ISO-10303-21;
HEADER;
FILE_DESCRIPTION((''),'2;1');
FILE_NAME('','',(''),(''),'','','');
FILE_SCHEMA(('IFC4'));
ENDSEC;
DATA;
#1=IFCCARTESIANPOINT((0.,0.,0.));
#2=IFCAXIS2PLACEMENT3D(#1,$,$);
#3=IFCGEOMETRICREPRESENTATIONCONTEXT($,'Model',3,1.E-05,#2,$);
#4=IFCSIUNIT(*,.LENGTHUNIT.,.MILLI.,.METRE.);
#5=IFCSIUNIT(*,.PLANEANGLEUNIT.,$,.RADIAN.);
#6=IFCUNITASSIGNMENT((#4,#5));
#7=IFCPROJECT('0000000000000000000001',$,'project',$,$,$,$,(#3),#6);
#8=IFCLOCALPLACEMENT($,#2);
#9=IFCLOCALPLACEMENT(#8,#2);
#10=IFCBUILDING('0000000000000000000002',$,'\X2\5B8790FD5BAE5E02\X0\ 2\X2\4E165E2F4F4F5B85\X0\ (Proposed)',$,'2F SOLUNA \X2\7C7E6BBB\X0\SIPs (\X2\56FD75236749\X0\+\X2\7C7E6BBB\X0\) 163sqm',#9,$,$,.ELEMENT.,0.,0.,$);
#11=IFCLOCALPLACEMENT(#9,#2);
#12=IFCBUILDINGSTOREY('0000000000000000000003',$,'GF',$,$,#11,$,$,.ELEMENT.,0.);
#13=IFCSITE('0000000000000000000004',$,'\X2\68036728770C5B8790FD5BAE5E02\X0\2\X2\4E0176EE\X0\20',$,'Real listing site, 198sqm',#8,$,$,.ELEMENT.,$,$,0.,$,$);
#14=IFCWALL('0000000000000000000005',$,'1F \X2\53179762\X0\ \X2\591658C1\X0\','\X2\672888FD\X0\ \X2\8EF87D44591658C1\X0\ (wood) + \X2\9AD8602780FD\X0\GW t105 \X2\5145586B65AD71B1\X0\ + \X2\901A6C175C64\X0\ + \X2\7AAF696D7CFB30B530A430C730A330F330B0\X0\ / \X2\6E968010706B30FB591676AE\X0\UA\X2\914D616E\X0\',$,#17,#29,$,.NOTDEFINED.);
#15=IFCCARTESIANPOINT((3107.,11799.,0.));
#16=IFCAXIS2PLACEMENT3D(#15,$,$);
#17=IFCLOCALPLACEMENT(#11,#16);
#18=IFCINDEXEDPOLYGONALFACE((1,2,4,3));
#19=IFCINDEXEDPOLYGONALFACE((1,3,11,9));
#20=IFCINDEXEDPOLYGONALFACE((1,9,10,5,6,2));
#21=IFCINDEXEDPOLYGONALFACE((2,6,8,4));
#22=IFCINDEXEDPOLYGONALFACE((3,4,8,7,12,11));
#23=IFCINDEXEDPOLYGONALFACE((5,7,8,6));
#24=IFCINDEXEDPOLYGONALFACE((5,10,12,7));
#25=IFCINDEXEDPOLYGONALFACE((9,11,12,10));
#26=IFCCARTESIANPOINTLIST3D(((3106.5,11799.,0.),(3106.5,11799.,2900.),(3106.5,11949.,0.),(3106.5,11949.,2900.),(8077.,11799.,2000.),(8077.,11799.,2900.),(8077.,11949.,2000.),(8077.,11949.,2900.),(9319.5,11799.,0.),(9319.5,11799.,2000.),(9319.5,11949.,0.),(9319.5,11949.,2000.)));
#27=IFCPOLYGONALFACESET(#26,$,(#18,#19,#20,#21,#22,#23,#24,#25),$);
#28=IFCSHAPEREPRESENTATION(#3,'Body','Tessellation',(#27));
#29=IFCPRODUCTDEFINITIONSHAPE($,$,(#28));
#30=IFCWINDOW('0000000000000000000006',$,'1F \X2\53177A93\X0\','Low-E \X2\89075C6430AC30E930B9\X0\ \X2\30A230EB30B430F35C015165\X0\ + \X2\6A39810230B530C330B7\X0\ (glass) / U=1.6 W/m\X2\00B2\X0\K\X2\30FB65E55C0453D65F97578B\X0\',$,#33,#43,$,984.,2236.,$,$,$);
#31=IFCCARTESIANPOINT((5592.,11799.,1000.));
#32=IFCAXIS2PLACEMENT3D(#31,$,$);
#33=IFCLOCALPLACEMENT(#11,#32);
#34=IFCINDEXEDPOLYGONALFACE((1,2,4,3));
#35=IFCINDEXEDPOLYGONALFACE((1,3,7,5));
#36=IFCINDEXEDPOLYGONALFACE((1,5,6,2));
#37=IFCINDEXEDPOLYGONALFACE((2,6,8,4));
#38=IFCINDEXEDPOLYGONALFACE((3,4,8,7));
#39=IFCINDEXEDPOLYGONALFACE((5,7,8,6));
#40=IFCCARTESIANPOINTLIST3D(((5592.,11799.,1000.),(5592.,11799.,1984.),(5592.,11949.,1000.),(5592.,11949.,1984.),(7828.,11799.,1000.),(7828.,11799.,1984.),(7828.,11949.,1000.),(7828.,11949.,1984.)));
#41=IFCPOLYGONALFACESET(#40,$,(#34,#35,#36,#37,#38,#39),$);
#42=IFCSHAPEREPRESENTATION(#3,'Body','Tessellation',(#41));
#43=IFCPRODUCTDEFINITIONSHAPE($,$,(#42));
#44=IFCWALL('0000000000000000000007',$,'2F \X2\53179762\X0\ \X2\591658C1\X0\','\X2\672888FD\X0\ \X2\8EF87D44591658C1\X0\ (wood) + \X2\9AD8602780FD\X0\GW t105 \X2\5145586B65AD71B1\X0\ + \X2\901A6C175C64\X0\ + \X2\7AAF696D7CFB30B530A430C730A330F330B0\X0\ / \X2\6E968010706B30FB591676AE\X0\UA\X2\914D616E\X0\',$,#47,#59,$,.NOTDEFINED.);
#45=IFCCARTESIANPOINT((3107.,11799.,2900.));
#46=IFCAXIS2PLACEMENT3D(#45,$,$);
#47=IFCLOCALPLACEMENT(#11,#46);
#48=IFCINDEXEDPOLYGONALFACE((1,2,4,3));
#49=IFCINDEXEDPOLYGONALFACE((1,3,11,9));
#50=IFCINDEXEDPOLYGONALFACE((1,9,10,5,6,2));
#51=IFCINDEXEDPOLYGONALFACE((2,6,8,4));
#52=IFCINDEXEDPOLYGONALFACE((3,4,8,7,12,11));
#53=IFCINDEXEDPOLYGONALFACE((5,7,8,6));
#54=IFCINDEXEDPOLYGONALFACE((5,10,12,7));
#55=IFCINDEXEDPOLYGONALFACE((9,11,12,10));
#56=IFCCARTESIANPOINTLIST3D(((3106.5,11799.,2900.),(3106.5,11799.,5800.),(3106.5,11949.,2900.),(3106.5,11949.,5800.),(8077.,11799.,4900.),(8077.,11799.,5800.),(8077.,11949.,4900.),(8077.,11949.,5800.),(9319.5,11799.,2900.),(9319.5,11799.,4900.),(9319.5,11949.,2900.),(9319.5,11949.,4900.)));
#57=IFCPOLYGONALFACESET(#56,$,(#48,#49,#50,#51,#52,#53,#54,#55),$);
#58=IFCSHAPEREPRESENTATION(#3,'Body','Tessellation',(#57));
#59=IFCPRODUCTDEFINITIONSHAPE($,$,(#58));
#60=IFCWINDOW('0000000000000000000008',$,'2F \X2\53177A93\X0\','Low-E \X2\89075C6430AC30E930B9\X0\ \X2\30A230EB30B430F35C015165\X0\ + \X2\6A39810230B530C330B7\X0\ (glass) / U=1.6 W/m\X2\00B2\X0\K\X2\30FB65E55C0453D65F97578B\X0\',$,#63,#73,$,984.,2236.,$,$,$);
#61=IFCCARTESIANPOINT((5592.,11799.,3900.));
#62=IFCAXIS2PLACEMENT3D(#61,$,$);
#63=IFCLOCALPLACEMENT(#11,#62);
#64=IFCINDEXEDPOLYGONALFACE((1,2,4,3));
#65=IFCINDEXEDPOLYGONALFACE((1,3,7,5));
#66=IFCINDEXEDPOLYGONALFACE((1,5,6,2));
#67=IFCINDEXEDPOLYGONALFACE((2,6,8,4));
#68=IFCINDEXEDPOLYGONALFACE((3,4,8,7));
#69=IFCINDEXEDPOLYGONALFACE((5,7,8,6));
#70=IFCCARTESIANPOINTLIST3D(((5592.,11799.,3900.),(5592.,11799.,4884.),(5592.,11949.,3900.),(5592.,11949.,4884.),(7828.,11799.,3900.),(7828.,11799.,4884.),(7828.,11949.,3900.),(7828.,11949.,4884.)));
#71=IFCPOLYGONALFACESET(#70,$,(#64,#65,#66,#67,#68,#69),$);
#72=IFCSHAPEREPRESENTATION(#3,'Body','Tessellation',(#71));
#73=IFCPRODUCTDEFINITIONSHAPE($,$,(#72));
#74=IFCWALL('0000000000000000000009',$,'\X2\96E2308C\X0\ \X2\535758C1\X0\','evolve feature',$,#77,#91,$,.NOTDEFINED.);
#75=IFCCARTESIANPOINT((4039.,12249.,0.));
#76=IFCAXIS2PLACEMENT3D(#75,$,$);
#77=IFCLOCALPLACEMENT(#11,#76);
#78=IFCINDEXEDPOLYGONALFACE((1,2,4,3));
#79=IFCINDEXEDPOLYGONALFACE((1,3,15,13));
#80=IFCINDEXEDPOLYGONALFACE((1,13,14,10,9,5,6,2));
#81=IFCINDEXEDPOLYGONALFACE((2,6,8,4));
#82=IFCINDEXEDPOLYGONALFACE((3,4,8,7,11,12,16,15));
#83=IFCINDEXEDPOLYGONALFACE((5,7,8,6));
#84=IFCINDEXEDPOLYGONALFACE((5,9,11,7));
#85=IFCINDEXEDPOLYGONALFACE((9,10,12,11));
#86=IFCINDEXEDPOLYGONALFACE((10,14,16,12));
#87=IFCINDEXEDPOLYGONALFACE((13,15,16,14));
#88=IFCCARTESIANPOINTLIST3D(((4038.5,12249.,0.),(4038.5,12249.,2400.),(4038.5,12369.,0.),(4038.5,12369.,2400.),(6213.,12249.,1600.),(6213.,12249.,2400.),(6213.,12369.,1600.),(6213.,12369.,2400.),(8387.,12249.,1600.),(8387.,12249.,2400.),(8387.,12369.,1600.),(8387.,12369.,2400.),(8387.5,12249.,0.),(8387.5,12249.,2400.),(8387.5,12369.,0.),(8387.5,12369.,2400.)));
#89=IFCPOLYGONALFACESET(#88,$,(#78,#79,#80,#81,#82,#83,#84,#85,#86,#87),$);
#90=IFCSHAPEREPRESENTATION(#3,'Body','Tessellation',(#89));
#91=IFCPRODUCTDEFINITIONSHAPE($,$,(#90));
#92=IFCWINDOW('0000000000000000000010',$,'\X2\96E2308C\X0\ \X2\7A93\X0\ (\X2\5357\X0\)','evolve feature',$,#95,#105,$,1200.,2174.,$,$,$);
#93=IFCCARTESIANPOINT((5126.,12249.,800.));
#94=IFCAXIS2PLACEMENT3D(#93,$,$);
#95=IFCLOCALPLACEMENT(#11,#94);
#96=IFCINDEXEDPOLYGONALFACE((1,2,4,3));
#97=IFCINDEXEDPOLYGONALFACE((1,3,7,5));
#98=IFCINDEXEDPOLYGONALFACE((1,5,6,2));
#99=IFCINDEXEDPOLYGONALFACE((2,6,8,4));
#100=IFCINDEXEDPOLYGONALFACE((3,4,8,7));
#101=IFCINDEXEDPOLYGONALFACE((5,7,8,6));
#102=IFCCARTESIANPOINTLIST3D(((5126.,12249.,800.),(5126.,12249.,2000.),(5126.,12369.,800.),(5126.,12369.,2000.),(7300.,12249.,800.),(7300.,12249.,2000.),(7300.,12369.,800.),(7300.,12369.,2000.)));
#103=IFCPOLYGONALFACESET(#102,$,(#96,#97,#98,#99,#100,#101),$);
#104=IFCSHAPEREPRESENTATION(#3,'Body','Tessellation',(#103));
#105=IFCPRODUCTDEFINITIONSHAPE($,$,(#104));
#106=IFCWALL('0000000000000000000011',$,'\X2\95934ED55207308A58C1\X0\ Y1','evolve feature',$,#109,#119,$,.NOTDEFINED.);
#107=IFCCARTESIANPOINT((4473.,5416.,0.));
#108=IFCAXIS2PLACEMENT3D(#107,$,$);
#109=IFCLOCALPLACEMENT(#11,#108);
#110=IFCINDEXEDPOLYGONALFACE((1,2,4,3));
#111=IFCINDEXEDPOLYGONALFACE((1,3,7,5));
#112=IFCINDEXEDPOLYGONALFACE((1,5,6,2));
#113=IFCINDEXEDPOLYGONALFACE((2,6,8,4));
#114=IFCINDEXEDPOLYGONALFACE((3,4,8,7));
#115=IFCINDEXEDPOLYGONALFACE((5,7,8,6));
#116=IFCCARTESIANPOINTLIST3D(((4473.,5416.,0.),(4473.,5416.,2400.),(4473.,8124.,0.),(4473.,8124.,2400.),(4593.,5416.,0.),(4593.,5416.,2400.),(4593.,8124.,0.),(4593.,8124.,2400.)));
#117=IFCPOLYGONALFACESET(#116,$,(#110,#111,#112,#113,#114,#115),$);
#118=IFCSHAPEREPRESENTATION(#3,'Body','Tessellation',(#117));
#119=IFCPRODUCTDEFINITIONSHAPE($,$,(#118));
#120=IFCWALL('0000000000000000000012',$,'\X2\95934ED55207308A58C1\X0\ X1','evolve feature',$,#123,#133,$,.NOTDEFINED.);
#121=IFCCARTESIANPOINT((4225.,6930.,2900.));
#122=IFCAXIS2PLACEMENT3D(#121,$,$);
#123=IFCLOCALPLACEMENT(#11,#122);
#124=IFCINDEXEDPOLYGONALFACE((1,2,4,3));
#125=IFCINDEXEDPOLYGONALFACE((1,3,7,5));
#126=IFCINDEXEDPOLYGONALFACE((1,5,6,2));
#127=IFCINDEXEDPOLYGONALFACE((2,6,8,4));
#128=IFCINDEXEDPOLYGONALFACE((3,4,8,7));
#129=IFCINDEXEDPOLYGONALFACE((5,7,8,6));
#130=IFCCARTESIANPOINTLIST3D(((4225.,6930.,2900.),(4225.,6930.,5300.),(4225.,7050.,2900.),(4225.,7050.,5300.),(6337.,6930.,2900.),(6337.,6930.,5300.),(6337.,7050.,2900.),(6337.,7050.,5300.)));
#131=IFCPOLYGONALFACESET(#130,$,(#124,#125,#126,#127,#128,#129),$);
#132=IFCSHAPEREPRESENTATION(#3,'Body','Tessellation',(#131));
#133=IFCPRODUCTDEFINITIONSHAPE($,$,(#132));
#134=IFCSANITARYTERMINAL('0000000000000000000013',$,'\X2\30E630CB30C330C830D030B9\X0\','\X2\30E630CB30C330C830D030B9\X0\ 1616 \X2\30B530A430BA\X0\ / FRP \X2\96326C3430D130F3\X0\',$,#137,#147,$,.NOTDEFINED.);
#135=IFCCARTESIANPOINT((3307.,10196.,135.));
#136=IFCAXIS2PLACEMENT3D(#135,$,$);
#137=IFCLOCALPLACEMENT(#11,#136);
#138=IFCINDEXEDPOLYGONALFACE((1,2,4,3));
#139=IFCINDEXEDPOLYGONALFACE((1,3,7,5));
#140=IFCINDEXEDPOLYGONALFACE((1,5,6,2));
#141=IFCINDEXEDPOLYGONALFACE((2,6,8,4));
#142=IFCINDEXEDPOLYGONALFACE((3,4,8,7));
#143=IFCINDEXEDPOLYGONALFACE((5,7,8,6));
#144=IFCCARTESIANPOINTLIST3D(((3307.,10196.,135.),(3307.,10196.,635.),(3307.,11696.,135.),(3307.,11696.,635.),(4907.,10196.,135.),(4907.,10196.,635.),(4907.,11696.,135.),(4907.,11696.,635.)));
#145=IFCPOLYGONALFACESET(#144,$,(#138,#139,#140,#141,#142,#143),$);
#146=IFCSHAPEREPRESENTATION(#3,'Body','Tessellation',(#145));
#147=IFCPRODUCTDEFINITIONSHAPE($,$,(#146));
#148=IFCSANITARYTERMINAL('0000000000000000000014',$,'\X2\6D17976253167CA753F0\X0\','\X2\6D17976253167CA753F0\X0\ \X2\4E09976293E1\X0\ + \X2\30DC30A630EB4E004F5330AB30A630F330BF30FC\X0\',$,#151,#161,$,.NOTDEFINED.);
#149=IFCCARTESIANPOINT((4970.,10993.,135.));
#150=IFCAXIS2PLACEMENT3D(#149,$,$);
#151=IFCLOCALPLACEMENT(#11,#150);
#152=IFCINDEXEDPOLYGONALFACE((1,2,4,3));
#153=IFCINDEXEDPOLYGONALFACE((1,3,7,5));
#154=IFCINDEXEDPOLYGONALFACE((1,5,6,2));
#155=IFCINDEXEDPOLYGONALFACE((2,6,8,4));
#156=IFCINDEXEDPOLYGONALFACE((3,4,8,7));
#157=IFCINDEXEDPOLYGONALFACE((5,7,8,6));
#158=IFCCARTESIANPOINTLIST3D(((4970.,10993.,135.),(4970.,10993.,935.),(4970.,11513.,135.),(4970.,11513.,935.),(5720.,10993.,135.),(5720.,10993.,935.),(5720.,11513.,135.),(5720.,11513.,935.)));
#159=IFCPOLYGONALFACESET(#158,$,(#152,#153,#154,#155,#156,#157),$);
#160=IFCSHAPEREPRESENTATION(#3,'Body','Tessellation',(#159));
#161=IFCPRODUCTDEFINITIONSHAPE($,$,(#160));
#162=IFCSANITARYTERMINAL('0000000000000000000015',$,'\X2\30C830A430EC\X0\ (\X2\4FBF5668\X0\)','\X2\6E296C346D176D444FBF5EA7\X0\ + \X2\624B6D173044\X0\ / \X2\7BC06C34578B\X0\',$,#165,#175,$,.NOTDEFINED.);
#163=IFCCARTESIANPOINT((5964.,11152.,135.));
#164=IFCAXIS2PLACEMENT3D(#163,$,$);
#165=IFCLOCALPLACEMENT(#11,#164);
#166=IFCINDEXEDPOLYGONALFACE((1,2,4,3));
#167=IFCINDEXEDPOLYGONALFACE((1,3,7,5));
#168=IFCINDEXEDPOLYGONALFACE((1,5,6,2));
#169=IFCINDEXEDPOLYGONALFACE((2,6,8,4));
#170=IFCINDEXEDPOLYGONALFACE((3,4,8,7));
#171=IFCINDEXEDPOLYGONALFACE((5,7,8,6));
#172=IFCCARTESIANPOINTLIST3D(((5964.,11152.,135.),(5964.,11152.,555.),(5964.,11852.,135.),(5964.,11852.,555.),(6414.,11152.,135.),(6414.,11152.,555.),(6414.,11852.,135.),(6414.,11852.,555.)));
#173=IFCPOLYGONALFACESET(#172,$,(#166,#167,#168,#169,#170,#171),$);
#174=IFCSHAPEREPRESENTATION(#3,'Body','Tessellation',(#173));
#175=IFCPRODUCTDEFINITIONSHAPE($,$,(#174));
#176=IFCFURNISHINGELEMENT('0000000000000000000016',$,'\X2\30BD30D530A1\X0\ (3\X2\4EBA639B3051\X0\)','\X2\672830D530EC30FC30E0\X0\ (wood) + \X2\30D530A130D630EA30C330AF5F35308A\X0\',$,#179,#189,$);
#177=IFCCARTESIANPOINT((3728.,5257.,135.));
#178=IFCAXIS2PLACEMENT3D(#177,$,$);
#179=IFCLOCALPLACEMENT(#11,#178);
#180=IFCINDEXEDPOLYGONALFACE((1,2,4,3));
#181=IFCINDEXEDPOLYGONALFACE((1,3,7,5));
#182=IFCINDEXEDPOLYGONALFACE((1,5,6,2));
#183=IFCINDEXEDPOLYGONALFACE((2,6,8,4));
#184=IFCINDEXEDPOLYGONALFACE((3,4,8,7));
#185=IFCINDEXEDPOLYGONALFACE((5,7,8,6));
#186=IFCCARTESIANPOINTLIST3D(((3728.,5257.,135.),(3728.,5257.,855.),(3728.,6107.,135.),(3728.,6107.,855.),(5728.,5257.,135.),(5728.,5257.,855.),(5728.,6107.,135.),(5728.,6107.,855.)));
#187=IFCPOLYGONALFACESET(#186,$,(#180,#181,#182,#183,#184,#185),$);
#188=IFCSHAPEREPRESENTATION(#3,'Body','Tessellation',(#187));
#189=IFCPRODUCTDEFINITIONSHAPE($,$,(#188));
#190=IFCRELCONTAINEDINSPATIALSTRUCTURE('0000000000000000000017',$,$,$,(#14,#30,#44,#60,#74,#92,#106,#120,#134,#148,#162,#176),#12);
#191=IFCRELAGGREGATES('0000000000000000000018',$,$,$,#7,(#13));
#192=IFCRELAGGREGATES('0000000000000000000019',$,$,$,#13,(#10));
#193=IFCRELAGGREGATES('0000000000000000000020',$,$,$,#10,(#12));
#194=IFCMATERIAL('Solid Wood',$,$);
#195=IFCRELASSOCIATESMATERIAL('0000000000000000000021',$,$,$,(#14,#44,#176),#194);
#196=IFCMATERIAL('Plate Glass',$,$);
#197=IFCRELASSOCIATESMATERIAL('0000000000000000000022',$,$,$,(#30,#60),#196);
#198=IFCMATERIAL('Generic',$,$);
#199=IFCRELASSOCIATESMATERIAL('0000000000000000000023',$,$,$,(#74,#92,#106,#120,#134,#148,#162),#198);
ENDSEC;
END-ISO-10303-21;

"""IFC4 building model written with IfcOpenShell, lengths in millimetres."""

from ifc_helpers import new_model, si_unit, frame, frame_2d, origin, place, context, project, spatial, rectangle, extrude, material, element, fill, save


model = new_model("IFC4")

# Units and contexts
model_context = context("Model", 3, precision=1e-05, world=origin())
ifc_project = project(units=[si_unit("LENGTHUNIT", "METRE", prefix="MILLI"), si_unit("PLANEANGLEUNIT", "RADIAN")], contexts=[model_context])

# Site, building, storey
site_placement = place(None, origin())
site = spatial("IfcSite", under=ifc_project, at=site_placement, Name="栃木県宇都宮市2丁目20", ObjectType="Real listing site, 198sqm", CompositionType="ELEMENT", RefElevation=0.0)
building_placement = place(site_placement, origin())
building = spatial("IfcBuilding", under=site, at=building_placement, Name="宇都宮市 2世帯住宅 (Proposed)", ObjectType="2F SOLUNA 籾殻SIPs (国産杉+籾殻) 163sqm", CompositionType="ELEMENT", ElevationOfRefHeight=0.0, ElevationOfTerrain=0.0)
storey_placement = place(building_placement, origin())
storey = spatial("IfcBuildingStorey", under=building, at=storey_placement, Name="GF", CompositionType="ELEMENT", Elevation=0.0)

# Shared definitions
ifc_material_1 = material(Name="Generic")

# Wall, opening, window
ifc_material_2 = material(Name="Solid Wood")
wall_1_placement = place(storey_placement, frame((3107.0, 11799.0, 0.0)))
wall_1 = element("IfcWall", 1, at=wall_1_placement, inside=storey, material=ifc_material_2, Name="1F 北面 外壁", Description="木製 軸組外壁 (wood) + 高性能GW t105 充填断熱 + 通気層 + 窯業系サイディング / 準耐火・外皮UA配慮", PredefinedType="NOTDEFINED", context=model_context, shape_type="SweptSolid", body=[
    extrude(rectangle(XDim=6213.0, YDim=150.0, at=frame_2d((3106.0, 75.0))), frame((3107.0, 11799.0, 0.0)), (0.0, 0.0, 1.0), 2900.0),
])
opening_1_placement = place(storey_placement, frame((5592.0, 11799.0, 1000.0)))
opening_1 = element("IfcOpeningElement", 2, at=opening_1_placement, cuts=wall_1, PredefinedType="NOTDEFINED", context=model_context, shape_type="SweptSolid", body=[
    extrude(rectangle(XDim=2236.0, YDim=150.0, at=frame_2d((1118.0, 75.0))), frame((5592.0, 11799.0, 1000.0)), (0.0, 0.0, 1.0), 984.0),
])
ifc_material_3 = material(Name="Plate Glass")
window_1_placement = place(storey_placement, frame((5592.0, 11799.0, 1000.0)))
window_1 = element("IfcWindow", 3, at=window_1_placement, inside=storey, material=ifc_material_3, Name="1F 北窓", Description="Low-E 複層ガラス アルゴン封入 + 樹脂サッシ (glass) / U=1.6 W/m²K・日射取得型", OverallHeight=984.0, OverallWidth=2236.0, context=model_context, shape_type="SweptSolid", body=[
    extrude(rectangle(XDim=2236.0, YDim=150.0, at=frame_2d((1118.0, 75.0))), frame((5592.0, 11799.0, 1000.0)), (0.0, 0.0, 1.0), 984.0),
])
fill(opening_1, window_1)

# Wall, opening, window
wall_2_placement = place(storey_placement, frame((3107.0, 11799.0, 2900.0)))
wall_2 = element("IfcWall", 4, at=wall_2_placement, inside=storey, material=ifc_material_2, Name="2F 北面 外壁", Description="木製 軸組外壁 (wood) + 高性能GW t105 充填断熱 + 通気層 + 窯業系サイディング / 準耐火・外皮UA配慮", PredefinedType="NOTDEFINED", context=model_context, shape_type="SweptSolid", body=[
    extrude(rectangle(XDim=6213.0, YDim=150.0, at=frame_2d((3106.0, 75.0))), frame((3107.0, 11799.0, 2900.0)), (0.0, 0.0, 1.0), 2900.0),
])
opening_2_placement = place(storey_placement, frame((5592.0, 11799.0, 3900.0)))
opening_2 = element("IfcOpeningElement", 5, at=opening_2_placement, cuts=wall_2, PredefinedType="NOTDEFINED", context=model_context, shape_type="SweptSolid", body=[
    extrude(rectangle(XDim=2236.0, YDim=150.0, at=frame_2d((1118.0, 75.0))), frame((5592.0, 11799.0, 3900.0)), (0.0, 0.0, 1.0), 984.0),
])
window_2_placement = place(storey_placement, frame((5592.0, 11799.0, 3900.0)))
window_2 = element("IfcWindow", 6, at=window_2_placement, inside=storey, material=ifc_material_3, Name="2F 北窓", Description="Low-E 複層ガラス アルゴン封入 + 樹脂サッシ (glass) / U=1.6 W/m²K・日射取得型", OverallHeight=984.0, OverallWidth=2236.0, context=model_context, shape_type="SweptSolid", body=[
    extrude(rectangle(XDim=2236.0, YDim=150.0, at=frame_2d((1118.0, 75.0))), frame((5592.0, 11799.0, 3900.0)), (0.0, 0.0, 1.0), 984.0),
])
fill(opening_2, window_2)

# Wall, opening, window
wall_3_placement = place(storey_placement, frame((4039.0, 12249.0, 0.0)))
wall_3 = element("IfcWall", 7, at=wall_3_placement, inside=storey, material=ifc_material_1, Name="離れ 南壁", Description="evolve feature", PredefinedType="NOTDEFINED", context=model_context, shape_type="SweptSolid", body=[
    extrude(rectangle(XDim=4349.0, YDim=120.0, at=frame_2d((2174.0, 60.0))), frame((4039.0, 12249.0, 0.0)), (0.0, 0.0, 1.0), 2400.0),
])
opening_3_placement = place(storey_placement, frame((5126.0, 12249.0, 800.0)))
opening_3 = element("IfcOpeningElement", 8, at=opening_3_placement, cuts=wall_3, PredefinedType="NOTDEFINED", context=model_context, shape_type="SweptSolid", body=[
    extrude(rectangle(XDim=2174.0, YDim=120.0, at=frame_2d((1087.0, 60.0))), frame((5126.0, 12249.0, 800.0)), (0.0, 0.0, 1.0), 1200.0),
])
window_3_placement = place(storey_placement, frame((5126.0, 12249.0, 800.0)))
window_3 = element("IfcWindow", 9, at=window_3_placement, inside=storey, material=ifc_material_1, Name="離れ 窓 (南)", Description="evolve feature", OverallHeight=1200.0, OverallWidth=2174.0, context=model_context, shape_type="SweptSolid", body=[
    extrude(rectangle(XDim=2174.0, YDim=120.0, at=frame_2d((1087.0, 60.0))), frame((5126.0, 12249.0, 800.0)), (0.0, 0.0, 1.0), 1200.0),
])
fill(opening_3, window_3)

# Walls
wall_4_placement = place(storey_placement, frame((4473.0, 5416.0, 0.0)))
element("IfcWall", 10, at=wall_4_placement, inside=storey, material=ifc_material_1, Name="間仕切り壁 Y1", Description="evolve feature", PredefinedType="NOTDEFINED", context=model_context, shape_type="SweptSolid", body=[
    extrude(rectangle(XDim=120.0, YDim=2708.0, at=frame_2d((60.0, 1354.0))), frame((4473.0, 5416.0, 0.0)), (0.0, 0.0, 1.0), 2400.0),
])
wall_5_placement = place(storey_placement, frame((4225.0, 6930.0, 2900.0)))
element("IfcWall", 11, at=wall_5_placement, inside=storey, material=ifc_material_1, Name="間仕切り壁 X1", Description="evolve feature", PredefinedType="NOTDEFINED", context=model_context, shape_type="SweptSolid", body=[
    extrude(rectangle(XDim=2112.0, YDim=120.0, at=frame_2d((1056.0, 60.0))), frame((4225.0, 6930.0, 2900.0)), (0.0, 0.0, 1.0), 2400.0),
])

# Sanitary terminals
sanitary_terminal_1_placement = place(storey_placement, frame((3307.0, 10196.0, 135.0)))
element("IfcSanitaryTerminal", 12, at=sanitary_terminal_1_placement, inside=storey, material=ifc_material_1, Name="ユニットバス", Description="ユニットバス 1616 サイズ / FRP 防水パン", PredefinedType="NOTDEFINED", context=model_context, shape_type="SweptSolid", body=[
    extrude(rectangle(XDim=1600.0, YDim=1500.0, at=frame_2d((800.0, 750.0))), frame((3307.0, 10196.0, 135.0)), (0.0, 0.0, 1.0), 500.0),
])
sanitary_terminal_2_placement = place(storey_placement, frame((4970.0, 10993.0, 135.0)))
element("IfcSanitaryTerminal", 13, at=sanitary_terminal_2_placement, inside=storey, material=ifc_material_1, Name="洗面化粧台", Description="洗面化粧台 三面鏡 + ボウル一体カウンター", PredefinedType="NOTDEFINED", context=model_context, shape_type="SweptSolid", body=[
    extrude(rectangle(XDim=750.0, YDim=520.0, at=frame_2d((375.0, 260.0))), frame((4970.0, 10993.0, 135.0)), (0.0, 0.0, 1.0), 800.0),
])
sanitary_terminal_3_placement = place(storey_placement, frame((5964.0, 11152.0, 135.0)))
element("IfcSanitaryTerminal", 14, at=sanitary_terminal_3_placement, inside=storey, material=ifc_material_1, Name="トイレ (便器)", Description="温水洗浄便座 + 手洗い / 節水型", PredefinedType="NOTDEFINED", context=model_context, shape_type="SweptSolid", body=[
    extrude(rectangle(XDim=450.0, YDim=700.0, at=frame_2d((225.0, 350.0))), frame((5964.0, 11152.0, 135.0)), (0.0, 0.0, 1.0), 420.0),
])

# Furnishing element
furnishing_1_placement = place(storey_placement, frame((3728.0, 5257.0, 135.0)))
element("IfcFurnishingElement", 15, at=furnishing_1_placement, inside=storey, material=ifc_material_2, Name="ソファ (3人掛け)", Description="木フレーム (wood) + ファブリック張り", context=model_context, shape_type="SweptSolid", body=[
    extrude(rectangle(XDim=2000.0, YDim=850.0, at=frame_2d((1000.0, 425.0))), frame((3728.0, 5257.0, 135.0)), (0.0, 0.0, 1.0), 720.0),
])

save(model, "model.ifc")
